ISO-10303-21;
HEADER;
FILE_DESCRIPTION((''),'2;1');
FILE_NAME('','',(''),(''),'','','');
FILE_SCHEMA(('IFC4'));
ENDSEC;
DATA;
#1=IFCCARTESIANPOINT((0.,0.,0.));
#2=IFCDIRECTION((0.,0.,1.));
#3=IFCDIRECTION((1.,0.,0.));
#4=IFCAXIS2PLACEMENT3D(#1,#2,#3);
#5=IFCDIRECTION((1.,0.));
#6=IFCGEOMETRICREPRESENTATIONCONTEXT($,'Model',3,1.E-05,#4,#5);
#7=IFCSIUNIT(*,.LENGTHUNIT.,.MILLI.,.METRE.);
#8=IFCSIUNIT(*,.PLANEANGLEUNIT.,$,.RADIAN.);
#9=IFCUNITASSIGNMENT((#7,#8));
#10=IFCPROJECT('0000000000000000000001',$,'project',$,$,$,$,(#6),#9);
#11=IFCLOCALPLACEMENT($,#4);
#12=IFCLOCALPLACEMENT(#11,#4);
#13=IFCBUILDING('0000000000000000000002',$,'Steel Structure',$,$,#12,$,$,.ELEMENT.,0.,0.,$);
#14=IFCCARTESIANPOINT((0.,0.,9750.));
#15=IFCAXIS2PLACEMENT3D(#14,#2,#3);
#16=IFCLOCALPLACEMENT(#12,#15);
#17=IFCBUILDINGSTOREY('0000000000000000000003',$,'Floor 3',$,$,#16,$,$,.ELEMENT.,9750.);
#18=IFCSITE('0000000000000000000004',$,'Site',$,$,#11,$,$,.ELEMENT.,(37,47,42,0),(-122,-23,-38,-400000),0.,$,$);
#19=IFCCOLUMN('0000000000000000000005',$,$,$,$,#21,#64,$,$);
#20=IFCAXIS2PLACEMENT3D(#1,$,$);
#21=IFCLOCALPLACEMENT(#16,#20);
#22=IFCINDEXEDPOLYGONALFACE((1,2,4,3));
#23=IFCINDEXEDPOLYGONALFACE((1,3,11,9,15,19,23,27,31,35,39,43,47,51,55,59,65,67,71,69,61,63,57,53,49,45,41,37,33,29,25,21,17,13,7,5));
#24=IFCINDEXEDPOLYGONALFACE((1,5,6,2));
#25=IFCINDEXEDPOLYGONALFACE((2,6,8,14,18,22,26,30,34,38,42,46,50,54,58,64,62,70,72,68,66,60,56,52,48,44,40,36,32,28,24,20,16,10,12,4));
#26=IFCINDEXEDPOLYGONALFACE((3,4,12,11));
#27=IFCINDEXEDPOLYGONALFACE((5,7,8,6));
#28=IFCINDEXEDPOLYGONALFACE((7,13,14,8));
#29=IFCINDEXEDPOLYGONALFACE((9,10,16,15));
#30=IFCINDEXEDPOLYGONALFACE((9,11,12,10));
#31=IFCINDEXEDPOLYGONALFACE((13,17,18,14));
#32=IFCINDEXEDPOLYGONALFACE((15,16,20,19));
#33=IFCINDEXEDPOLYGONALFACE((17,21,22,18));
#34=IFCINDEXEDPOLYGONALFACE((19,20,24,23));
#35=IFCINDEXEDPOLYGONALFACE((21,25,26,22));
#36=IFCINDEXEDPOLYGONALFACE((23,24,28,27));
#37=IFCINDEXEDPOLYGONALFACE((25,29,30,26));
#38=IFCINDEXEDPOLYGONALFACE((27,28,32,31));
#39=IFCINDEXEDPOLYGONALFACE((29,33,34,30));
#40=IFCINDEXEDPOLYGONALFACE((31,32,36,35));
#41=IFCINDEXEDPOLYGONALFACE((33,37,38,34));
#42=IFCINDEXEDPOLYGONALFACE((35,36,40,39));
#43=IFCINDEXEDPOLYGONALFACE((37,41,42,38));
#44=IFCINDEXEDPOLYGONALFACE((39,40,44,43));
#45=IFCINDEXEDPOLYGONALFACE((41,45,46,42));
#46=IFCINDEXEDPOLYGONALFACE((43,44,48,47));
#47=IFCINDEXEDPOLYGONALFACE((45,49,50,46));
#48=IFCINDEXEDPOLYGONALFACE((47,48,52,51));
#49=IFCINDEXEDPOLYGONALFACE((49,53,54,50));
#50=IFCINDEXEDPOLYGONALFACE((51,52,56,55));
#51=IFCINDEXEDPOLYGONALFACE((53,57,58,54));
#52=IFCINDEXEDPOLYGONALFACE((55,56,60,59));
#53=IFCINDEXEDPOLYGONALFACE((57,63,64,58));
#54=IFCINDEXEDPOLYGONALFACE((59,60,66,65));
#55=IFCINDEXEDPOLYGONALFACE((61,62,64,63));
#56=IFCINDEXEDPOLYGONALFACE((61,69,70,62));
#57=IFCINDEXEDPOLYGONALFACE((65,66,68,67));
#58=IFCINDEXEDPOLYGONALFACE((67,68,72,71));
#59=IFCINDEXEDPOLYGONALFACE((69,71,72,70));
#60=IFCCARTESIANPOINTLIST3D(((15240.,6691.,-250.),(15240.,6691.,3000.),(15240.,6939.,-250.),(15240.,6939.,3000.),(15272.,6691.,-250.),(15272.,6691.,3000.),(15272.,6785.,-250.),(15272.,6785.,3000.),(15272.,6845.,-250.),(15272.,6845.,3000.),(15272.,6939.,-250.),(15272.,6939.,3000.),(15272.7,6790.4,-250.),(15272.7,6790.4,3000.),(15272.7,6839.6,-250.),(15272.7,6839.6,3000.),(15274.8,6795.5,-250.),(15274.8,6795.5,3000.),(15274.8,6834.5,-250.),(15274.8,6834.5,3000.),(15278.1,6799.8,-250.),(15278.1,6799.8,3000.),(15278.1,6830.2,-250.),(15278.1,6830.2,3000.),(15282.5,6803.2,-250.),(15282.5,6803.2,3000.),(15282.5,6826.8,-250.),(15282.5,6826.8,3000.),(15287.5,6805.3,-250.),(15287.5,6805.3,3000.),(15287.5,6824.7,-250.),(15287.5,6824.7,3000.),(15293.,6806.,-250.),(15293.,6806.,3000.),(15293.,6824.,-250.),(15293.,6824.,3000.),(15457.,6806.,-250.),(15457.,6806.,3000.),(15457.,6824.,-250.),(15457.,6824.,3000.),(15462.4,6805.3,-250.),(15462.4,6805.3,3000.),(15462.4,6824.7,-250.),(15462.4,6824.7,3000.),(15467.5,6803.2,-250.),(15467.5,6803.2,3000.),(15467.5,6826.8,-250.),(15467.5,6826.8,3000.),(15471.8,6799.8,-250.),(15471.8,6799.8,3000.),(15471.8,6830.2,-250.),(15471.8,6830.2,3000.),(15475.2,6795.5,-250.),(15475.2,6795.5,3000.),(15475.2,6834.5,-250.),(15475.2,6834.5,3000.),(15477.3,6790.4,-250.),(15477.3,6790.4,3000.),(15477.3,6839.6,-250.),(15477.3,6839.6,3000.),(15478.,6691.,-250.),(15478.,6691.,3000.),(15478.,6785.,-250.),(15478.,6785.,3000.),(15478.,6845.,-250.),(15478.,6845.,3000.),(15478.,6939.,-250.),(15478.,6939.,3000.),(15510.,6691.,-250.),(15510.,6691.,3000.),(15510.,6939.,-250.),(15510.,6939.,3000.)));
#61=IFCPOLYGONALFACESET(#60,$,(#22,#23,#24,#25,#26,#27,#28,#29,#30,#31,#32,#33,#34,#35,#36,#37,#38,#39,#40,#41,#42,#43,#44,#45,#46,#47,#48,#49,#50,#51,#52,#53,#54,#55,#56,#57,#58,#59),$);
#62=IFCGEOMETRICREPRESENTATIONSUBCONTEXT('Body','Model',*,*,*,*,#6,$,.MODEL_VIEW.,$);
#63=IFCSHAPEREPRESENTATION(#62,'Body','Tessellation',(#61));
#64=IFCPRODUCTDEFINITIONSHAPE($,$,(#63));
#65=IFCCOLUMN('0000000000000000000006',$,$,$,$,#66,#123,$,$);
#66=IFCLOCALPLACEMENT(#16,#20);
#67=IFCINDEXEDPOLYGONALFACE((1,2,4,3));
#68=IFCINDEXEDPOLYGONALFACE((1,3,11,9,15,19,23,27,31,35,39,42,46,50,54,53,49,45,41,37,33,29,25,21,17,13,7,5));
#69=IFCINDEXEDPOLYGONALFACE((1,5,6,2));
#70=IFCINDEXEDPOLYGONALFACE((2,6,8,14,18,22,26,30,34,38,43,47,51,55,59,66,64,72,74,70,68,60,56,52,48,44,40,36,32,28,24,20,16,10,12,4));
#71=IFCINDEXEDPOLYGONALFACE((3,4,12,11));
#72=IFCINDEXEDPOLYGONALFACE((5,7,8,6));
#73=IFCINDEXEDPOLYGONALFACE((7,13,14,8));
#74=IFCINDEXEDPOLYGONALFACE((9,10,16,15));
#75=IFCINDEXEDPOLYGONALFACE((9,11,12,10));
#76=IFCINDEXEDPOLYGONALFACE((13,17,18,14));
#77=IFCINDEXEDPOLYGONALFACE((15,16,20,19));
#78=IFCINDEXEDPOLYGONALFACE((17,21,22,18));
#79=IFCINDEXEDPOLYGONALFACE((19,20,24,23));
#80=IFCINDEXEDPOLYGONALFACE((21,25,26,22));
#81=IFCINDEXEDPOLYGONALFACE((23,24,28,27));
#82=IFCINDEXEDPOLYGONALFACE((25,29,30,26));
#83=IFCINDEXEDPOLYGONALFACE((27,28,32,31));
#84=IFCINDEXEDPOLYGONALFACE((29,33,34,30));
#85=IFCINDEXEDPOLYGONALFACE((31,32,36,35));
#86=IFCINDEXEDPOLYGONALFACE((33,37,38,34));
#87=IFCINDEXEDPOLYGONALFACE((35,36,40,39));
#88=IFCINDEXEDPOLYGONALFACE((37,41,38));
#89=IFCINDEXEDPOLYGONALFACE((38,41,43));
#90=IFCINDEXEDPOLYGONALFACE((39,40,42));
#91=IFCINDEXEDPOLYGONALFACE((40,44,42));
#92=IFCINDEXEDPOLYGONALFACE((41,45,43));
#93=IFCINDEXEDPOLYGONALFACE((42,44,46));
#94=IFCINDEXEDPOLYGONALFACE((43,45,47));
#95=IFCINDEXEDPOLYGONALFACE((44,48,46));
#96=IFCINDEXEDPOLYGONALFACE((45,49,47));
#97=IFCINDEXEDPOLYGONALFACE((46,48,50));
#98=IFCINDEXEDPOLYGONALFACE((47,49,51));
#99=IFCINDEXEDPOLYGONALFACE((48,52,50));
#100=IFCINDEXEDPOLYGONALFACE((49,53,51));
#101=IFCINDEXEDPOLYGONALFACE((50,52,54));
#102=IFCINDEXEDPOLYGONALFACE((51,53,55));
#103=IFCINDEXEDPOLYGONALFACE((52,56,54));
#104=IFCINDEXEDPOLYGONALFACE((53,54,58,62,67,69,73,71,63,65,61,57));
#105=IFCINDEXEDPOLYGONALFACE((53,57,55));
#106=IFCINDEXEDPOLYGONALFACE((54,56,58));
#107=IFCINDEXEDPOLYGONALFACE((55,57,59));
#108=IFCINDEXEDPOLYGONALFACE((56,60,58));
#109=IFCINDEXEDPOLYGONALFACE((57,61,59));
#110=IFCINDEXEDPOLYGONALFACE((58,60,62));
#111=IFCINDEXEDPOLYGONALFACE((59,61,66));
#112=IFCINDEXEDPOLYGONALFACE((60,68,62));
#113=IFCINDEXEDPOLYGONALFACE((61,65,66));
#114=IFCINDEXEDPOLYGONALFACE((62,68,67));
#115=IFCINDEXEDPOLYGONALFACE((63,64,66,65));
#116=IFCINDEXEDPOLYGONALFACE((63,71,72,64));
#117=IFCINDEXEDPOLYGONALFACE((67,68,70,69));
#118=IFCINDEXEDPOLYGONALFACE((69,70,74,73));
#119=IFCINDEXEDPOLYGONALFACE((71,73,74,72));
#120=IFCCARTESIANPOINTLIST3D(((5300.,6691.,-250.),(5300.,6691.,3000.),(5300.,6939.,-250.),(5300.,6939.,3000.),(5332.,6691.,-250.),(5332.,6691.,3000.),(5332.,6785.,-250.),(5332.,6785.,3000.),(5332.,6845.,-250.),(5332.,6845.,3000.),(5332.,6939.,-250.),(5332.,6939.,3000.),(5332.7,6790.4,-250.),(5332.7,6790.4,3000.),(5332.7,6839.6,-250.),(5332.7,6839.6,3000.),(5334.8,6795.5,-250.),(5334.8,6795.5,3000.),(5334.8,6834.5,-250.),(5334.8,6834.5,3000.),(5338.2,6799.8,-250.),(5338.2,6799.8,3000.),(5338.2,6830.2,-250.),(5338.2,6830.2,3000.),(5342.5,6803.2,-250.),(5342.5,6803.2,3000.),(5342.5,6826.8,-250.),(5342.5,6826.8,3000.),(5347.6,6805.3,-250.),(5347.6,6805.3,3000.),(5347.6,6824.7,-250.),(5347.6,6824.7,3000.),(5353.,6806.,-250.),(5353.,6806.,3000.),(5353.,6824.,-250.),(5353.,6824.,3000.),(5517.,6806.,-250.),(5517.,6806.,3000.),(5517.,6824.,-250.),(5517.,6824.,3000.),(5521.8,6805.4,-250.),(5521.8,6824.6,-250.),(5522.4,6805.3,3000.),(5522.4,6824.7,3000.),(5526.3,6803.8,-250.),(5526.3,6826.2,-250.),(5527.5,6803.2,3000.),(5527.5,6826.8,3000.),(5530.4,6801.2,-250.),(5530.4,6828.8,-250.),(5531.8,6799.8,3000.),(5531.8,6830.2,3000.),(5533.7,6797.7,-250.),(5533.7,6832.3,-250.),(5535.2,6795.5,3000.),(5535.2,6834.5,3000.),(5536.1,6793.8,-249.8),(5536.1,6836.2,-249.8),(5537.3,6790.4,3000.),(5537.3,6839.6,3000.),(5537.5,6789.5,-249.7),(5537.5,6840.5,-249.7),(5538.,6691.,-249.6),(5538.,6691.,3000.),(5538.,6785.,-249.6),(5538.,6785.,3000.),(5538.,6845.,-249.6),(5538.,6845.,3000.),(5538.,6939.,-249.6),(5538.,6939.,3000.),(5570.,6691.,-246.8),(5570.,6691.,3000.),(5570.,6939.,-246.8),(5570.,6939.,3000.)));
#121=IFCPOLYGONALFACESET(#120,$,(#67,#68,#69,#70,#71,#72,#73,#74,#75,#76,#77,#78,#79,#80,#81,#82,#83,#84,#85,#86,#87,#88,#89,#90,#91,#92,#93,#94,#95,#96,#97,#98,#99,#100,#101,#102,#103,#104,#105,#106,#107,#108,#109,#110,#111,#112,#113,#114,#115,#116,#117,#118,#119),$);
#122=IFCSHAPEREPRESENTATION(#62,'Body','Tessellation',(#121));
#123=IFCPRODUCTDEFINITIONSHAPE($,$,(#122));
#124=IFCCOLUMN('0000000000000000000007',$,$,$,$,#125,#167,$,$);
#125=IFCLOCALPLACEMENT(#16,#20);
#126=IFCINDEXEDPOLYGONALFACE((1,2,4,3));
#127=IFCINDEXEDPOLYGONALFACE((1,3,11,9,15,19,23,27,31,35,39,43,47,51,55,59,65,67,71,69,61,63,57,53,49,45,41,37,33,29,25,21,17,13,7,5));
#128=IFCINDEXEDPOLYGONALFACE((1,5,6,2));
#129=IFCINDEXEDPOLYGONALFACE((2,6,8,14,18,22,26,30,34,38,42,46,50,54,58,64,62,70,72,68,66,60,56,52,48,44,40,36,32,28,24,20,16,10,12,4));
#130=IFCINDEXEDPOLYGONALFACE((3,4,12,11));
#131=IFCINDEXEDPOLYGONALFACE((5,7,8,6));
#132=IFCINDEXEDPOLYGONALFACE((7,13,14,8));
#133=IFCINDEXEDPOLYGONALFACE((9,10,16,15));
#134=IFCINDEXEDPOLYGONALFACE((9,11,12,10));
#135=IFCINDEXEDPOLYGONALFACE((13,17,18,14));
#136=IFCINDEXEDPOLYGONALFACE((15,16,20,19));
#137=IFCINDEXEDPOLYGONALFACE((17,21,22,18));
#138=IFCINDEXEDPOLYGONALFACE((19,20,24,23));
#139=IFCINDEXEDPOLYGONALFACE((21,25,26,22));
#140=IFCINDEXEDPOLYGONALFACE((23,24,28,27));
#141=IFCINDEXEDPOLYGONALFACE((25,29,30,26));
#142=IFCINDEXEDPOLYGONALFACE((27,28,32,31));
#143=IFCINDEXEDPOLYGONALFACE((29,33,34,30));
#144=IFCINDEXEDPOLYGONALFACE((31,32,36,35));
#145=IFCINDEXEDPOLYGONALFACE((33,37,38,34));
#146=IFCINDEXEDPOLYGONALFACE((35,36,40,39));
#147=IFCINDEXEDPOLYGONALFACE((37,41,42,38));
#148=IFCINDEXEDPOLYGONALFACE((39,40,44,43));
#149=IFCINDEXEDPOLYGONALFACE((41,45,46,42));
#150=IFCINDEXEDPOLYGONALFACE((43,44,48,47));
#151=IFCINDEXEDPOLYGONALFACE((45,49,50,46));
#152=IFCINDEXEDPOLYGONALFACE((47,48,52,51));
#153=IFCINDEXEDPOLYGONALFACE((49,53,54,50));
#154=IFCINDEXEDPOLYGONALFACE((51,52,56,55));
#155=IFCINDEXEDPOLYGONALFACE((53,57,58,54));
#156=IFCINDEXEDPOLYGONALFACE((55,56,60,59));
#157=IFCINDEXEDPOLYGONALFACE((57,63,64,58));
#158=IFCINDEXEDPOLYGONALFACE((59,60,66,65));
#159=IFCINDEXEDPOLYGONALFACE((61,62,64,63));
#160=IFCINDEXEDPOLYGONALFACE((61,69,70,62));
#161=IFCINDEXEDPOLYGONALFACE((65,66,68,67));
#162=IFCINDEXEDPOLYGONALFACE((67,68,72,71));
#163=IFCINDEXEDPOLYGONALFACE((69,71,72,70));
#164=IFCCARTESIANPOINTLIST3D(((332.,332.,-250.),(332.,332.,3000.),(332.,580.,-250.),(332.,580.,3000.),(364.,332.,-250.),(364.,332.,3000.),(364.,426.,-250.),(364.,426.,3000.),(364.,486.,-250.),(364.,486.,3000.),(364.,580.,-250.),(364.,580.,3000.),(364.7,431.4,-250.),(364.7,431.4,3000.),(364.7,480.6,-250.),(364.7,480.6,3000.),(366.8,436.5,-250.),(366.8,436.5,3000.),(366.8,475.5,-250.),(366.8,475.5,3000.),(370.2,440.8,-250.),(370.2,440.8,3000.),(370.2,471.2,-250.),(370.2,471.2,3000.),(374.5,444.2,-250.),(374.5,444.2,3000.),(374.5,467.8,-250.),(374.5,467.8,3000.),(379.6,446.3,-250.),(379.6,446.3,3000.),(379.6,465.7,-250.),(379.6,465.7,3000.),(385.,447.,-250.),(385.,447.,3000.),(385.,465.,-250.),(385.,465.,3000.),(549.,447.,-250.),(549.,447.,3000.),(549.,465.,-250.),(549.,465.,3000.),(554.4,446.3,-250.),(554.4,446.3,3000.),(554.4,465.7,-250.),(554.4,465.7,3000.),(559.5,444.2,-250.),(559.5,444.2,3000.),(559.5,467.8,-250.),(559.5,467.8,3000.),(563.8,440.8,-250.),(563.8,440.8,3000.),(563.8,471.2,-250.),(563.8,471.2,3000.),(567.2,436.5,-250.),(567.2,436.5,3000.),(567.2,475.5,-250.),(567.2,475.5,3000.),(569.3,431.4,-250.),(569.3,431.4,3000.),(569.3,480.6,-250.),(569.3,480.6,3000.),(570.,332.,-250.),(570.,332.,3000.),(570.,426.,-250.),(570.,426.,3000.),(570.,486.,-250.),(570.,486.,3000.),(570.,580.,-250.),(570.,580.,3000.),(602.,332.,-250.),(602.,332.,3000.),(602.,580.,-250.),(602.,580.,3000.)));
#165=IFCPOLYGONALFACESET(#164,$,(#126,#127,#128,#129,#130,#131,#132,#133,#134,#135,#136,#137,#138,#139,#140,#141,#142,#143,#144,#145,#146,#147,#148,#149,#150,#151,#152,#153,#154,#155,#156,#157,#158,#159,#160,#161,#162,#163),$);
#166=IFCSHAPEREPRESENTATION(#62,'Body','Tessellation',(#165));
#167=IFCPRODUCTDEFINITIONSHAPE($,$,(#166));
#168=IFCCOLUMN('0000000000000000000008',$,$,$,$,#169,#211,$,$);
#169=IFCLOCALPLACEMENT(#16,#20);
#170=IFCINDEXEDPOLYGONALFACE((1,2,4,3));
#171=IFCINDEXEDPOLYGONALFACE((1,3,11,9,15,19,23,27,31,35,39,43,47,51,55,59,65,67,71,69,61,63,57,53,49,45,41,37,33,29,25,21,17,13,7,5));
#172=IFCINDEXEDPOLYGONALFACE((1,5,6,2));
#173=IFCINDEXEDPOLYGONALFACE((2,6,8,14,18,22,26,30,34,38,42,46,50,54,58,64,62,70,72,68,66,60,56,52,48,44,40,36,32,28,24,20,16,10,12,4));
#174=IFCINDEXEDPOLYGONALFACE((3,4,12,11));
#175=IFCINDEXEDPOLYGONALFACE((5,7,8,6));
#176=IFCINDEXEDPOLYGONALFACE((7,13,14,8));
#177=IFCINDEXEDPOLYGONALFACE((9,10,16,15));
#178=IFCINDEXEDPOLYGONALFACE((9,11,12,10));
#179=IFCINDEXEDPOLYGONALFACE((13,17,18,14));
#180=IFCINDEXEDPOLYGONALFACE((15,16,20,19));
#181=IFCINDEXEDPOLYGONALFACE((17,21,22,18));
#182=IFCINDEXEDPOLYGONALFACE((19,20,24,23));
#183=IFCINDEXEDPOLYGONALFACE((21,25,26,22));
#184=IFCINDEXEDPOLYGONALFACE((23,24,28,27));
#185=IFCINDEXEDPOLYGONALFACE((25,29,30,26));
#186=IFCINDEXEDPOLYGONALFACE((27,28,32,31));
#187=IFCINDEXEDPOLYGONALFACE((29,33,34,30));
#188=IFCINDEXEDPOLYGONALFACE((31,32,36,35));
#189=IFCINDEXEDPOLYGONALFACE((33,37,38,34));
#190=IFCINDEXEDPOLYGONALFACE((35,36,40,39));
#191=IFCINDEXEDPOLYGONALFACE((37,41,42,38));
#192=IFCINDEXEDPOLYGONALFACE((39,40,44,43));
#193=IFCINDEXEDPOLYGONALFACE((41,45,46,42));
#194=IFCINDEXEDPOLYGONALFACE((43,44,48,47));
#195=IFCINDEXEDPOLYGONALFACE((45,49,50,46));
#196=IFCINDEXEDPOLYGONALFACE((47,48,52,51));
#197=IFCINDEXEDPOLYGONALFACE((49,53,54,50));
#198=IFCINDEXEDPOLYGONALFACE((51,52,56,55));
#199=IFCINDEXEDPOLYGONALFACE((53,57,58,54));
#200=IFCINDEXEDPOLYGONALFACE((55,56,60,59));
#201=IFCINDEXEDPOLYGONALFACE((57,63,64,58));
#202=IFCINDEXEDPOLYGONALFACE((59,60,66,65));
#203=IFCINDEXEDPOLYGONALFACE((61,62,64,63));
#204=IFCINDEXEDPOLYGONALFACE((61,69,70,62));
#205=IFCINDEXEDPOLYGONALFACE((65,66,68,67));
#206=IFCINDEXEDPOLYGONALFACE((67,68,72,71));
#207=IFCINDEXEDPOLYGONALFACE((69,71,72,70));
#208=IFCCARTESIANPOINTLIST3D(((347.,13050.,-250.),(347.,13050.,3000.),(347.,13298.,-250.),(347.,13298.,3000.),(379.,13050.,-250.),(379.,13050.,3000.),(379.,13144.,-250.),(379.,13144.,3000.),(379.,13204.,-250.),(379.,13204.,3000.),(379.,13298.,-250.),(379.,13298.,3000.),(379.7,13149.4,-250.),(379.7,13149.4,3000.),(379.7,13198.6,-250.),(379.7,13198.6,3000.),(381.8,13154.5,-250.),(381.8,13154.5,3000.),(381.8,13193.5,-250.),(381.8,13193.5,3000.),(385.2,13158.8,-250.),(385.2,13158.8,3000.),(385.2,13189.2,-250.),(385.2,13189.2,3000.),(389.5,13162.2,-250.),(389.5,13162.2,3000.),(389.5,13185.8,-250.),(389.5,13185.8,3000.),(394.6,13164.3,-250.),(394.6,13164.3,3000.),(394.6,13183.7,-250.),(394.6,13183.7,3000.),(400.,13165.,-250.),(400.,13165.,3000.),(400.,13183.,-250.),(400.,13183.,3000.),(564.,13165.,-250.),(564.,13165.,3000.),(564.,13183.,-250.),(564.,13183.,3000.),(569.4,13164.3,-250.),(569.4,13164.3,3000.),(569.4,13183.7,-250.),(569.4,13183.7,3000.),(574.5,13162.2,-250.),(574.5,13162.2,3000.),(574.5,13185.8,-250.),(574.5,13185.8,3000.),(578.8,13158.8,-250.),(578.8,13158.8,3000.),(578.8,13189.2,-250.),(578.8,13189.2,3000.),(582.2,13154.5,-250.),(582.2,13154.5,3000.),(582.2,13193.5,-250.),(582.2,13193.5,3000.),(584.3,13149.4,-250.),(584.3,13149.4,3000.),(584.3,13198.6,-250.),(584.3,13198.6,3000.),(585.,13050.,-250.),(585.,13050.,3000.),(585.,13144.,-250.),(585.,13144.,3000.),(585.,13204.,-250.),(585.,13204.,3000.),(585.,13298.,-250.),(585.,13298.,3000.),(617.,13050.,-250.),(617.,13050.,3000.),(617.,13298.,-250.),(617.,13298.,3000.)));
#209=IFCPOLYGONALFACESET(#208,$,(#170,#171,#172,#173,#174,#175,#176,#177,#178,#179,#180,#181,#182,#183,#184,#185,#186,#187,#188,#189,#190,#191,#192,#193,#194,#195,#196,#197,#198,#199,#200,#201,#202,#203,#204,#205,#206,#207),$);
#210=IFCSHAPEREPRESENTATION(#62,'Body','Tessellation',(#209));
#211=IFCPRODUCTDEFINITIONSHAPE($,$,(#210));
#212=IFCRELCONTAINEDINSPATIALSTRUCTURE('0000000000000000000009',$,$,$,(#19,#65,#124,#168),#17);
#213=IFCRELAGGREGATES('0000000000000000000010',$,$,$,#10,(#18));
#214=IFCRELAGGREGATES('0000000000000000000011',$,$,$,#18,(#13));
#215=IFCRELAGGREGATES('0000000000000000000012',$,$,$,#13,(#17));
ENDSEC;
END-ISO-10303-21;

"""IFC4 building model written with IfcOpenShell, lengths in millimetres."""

from ifc_helpers import new_model, si_unit, direction, frame, origin_with_axes, origin_2d_with_axis, place, context, subcontext, project, spatial, polyline, i_section, extrude, clip, bounded_halfspace, element, save


model = new_model("IFC4")

# Units and contexts
model_context = context("Model", 3, precision=1e-05, world=origin_with_axes(), true_north=direction((1.0, 0.0)))
body_context = subcontext(model_context, "Body", "Model", "MODEL_VIEW")
ifc_project = project(units=[si_unit("LENGTHUNIT", "METRE", prefix="MILLI"), si_unit("PLANEANGLEUNIT", "RADIAN")], contexts=[model_context])

# Site, building, storey
site_placement = place(None, origin_with_axes())
site = spatial("IfcSite", under=ifc_project, at=site_placement, Name="Site", CompositionType="ELEMENT", RefLatitude=(37, 47, 42, 0), RefLongitude=(-122, -23, -38, -400000), RefElevation=0.0)
building_placement = place(site_placement, origin_with_axes())
building = spatial("IfcBuilding", under=site, at=building_placement, Name="Steel Structure", CompositionType="ELEMENT", ElevationOfRefHeight=0.0, ElevationOfTerrain=0.0)
storey_placement = place(building_placement, frame((0.0, 0.0, 9750.0), z_axis=(0.0, 0.0, 1.0), x_axis=(1.0, 0.0, 0.0)))
storey = spatial("IfcBuildingStorey", under=building, at=storey_placement, Name="Floor 3", CompositionType="ELEMENT", Elevation=9750.0)

# Columns
column_1_placement = place(storey_placement, frame((15375.0, 6815.0, -250.0), z_axis=(0.0, 0.0, 1.0), x_axis=(0.0, -1.0, 0.0)))
element("IfcColumn", 1, at=column_1_placement, inside=storey, context=body_context, shape_type="SweptSolid", body=[
    extrude(i_section(OverallWidth=248.0, OverallDepth=270.0, WebThickness=18.0, FlangeThickness=32.0, FilletRadius=21.0, at=origin_2d_with_axis()), origin_with_axes(), (0.0, 0.0, 1.0), 3250.0),
])
column_2_placement = place(storey_placement, frame((5435.0, 6815.0, -250.0), z_axis=(0.0, 0.0, 1.0), x_axis=(0.0, -1.0, 0.0)))
element("IfcColumn", 2, at=column_2_placement, inside=storey, context=body_context, shape_type="Clipping", body=[
    clip(extrude(i_section(OverallWidth=248.0, OverallDepth=270.0, WebThickness=18.0, FlangeThickness=32.0, FilletRadius=21.0, at=origin_2d_with_axis()), origin_with_axes(), (0.0, 0.0, 1.0), 3250.0), bounded_halfspace(frame((6815.0, -6217.8, -552.6), z_axis=(0.0, 0.087156, -0.996195), x_axis=(-1.0, 0.0, 0.0)), False, origin_with_axes(), polyline([(-17.3, 98.7), (-30.0, 103.0), (-124.0, 103.0), (-124.0, 135.0), (124.0, 135.0), (124.0, 103.0), (30.0, 103.0), (17.3, 98.7), (-17.3, 98.7)]))),
])
column_3_placement = place(storey_placement, frame((467.0, 456.0, -250.0), z_axis=(0.0, 0.0, 1.0), x_axis=(0.0, 1.0, 0.0)))
element("IfcColumn", 3, at=column_3_placement, inside=storey, context=body_context, shape_type="SweptSolid", body=[
    extrude(i_section(OverallWidth=248.0, OverallDepth=270.0, WebThickness=18.0, FlangeThickness=32.0, FilletRadius=21.0, at=origin_2d_with_axis()), origin_with_axes(), (0.0, 0.0, 1.0), 3250.0),
])
for number, where, z_axis, x_axis in (
    (4, (482.0, 13174.0, -250.0), (0.0, 0.0, 1.0), (0.0, -1.0, 0.0)),
):
    element("IfcColumn", number, at=place(storey_placement, frame(where, z_axis=z_axis, x_axis=x_axis)), inside=storey, context=body_context, shape_type="SweptSolid", body=[
        extrude(i_section(OverallWidth=248.0, OverallDepth=270.0, WebThickness=18.0, FlangeThickness=32.0, FilletRadius=21.0, at=origin_2d_with_axis()), origin_with_axes(), (0.0, 0.0, 1.0), 3250.0),
    ])

save(model, "model.ifc")
